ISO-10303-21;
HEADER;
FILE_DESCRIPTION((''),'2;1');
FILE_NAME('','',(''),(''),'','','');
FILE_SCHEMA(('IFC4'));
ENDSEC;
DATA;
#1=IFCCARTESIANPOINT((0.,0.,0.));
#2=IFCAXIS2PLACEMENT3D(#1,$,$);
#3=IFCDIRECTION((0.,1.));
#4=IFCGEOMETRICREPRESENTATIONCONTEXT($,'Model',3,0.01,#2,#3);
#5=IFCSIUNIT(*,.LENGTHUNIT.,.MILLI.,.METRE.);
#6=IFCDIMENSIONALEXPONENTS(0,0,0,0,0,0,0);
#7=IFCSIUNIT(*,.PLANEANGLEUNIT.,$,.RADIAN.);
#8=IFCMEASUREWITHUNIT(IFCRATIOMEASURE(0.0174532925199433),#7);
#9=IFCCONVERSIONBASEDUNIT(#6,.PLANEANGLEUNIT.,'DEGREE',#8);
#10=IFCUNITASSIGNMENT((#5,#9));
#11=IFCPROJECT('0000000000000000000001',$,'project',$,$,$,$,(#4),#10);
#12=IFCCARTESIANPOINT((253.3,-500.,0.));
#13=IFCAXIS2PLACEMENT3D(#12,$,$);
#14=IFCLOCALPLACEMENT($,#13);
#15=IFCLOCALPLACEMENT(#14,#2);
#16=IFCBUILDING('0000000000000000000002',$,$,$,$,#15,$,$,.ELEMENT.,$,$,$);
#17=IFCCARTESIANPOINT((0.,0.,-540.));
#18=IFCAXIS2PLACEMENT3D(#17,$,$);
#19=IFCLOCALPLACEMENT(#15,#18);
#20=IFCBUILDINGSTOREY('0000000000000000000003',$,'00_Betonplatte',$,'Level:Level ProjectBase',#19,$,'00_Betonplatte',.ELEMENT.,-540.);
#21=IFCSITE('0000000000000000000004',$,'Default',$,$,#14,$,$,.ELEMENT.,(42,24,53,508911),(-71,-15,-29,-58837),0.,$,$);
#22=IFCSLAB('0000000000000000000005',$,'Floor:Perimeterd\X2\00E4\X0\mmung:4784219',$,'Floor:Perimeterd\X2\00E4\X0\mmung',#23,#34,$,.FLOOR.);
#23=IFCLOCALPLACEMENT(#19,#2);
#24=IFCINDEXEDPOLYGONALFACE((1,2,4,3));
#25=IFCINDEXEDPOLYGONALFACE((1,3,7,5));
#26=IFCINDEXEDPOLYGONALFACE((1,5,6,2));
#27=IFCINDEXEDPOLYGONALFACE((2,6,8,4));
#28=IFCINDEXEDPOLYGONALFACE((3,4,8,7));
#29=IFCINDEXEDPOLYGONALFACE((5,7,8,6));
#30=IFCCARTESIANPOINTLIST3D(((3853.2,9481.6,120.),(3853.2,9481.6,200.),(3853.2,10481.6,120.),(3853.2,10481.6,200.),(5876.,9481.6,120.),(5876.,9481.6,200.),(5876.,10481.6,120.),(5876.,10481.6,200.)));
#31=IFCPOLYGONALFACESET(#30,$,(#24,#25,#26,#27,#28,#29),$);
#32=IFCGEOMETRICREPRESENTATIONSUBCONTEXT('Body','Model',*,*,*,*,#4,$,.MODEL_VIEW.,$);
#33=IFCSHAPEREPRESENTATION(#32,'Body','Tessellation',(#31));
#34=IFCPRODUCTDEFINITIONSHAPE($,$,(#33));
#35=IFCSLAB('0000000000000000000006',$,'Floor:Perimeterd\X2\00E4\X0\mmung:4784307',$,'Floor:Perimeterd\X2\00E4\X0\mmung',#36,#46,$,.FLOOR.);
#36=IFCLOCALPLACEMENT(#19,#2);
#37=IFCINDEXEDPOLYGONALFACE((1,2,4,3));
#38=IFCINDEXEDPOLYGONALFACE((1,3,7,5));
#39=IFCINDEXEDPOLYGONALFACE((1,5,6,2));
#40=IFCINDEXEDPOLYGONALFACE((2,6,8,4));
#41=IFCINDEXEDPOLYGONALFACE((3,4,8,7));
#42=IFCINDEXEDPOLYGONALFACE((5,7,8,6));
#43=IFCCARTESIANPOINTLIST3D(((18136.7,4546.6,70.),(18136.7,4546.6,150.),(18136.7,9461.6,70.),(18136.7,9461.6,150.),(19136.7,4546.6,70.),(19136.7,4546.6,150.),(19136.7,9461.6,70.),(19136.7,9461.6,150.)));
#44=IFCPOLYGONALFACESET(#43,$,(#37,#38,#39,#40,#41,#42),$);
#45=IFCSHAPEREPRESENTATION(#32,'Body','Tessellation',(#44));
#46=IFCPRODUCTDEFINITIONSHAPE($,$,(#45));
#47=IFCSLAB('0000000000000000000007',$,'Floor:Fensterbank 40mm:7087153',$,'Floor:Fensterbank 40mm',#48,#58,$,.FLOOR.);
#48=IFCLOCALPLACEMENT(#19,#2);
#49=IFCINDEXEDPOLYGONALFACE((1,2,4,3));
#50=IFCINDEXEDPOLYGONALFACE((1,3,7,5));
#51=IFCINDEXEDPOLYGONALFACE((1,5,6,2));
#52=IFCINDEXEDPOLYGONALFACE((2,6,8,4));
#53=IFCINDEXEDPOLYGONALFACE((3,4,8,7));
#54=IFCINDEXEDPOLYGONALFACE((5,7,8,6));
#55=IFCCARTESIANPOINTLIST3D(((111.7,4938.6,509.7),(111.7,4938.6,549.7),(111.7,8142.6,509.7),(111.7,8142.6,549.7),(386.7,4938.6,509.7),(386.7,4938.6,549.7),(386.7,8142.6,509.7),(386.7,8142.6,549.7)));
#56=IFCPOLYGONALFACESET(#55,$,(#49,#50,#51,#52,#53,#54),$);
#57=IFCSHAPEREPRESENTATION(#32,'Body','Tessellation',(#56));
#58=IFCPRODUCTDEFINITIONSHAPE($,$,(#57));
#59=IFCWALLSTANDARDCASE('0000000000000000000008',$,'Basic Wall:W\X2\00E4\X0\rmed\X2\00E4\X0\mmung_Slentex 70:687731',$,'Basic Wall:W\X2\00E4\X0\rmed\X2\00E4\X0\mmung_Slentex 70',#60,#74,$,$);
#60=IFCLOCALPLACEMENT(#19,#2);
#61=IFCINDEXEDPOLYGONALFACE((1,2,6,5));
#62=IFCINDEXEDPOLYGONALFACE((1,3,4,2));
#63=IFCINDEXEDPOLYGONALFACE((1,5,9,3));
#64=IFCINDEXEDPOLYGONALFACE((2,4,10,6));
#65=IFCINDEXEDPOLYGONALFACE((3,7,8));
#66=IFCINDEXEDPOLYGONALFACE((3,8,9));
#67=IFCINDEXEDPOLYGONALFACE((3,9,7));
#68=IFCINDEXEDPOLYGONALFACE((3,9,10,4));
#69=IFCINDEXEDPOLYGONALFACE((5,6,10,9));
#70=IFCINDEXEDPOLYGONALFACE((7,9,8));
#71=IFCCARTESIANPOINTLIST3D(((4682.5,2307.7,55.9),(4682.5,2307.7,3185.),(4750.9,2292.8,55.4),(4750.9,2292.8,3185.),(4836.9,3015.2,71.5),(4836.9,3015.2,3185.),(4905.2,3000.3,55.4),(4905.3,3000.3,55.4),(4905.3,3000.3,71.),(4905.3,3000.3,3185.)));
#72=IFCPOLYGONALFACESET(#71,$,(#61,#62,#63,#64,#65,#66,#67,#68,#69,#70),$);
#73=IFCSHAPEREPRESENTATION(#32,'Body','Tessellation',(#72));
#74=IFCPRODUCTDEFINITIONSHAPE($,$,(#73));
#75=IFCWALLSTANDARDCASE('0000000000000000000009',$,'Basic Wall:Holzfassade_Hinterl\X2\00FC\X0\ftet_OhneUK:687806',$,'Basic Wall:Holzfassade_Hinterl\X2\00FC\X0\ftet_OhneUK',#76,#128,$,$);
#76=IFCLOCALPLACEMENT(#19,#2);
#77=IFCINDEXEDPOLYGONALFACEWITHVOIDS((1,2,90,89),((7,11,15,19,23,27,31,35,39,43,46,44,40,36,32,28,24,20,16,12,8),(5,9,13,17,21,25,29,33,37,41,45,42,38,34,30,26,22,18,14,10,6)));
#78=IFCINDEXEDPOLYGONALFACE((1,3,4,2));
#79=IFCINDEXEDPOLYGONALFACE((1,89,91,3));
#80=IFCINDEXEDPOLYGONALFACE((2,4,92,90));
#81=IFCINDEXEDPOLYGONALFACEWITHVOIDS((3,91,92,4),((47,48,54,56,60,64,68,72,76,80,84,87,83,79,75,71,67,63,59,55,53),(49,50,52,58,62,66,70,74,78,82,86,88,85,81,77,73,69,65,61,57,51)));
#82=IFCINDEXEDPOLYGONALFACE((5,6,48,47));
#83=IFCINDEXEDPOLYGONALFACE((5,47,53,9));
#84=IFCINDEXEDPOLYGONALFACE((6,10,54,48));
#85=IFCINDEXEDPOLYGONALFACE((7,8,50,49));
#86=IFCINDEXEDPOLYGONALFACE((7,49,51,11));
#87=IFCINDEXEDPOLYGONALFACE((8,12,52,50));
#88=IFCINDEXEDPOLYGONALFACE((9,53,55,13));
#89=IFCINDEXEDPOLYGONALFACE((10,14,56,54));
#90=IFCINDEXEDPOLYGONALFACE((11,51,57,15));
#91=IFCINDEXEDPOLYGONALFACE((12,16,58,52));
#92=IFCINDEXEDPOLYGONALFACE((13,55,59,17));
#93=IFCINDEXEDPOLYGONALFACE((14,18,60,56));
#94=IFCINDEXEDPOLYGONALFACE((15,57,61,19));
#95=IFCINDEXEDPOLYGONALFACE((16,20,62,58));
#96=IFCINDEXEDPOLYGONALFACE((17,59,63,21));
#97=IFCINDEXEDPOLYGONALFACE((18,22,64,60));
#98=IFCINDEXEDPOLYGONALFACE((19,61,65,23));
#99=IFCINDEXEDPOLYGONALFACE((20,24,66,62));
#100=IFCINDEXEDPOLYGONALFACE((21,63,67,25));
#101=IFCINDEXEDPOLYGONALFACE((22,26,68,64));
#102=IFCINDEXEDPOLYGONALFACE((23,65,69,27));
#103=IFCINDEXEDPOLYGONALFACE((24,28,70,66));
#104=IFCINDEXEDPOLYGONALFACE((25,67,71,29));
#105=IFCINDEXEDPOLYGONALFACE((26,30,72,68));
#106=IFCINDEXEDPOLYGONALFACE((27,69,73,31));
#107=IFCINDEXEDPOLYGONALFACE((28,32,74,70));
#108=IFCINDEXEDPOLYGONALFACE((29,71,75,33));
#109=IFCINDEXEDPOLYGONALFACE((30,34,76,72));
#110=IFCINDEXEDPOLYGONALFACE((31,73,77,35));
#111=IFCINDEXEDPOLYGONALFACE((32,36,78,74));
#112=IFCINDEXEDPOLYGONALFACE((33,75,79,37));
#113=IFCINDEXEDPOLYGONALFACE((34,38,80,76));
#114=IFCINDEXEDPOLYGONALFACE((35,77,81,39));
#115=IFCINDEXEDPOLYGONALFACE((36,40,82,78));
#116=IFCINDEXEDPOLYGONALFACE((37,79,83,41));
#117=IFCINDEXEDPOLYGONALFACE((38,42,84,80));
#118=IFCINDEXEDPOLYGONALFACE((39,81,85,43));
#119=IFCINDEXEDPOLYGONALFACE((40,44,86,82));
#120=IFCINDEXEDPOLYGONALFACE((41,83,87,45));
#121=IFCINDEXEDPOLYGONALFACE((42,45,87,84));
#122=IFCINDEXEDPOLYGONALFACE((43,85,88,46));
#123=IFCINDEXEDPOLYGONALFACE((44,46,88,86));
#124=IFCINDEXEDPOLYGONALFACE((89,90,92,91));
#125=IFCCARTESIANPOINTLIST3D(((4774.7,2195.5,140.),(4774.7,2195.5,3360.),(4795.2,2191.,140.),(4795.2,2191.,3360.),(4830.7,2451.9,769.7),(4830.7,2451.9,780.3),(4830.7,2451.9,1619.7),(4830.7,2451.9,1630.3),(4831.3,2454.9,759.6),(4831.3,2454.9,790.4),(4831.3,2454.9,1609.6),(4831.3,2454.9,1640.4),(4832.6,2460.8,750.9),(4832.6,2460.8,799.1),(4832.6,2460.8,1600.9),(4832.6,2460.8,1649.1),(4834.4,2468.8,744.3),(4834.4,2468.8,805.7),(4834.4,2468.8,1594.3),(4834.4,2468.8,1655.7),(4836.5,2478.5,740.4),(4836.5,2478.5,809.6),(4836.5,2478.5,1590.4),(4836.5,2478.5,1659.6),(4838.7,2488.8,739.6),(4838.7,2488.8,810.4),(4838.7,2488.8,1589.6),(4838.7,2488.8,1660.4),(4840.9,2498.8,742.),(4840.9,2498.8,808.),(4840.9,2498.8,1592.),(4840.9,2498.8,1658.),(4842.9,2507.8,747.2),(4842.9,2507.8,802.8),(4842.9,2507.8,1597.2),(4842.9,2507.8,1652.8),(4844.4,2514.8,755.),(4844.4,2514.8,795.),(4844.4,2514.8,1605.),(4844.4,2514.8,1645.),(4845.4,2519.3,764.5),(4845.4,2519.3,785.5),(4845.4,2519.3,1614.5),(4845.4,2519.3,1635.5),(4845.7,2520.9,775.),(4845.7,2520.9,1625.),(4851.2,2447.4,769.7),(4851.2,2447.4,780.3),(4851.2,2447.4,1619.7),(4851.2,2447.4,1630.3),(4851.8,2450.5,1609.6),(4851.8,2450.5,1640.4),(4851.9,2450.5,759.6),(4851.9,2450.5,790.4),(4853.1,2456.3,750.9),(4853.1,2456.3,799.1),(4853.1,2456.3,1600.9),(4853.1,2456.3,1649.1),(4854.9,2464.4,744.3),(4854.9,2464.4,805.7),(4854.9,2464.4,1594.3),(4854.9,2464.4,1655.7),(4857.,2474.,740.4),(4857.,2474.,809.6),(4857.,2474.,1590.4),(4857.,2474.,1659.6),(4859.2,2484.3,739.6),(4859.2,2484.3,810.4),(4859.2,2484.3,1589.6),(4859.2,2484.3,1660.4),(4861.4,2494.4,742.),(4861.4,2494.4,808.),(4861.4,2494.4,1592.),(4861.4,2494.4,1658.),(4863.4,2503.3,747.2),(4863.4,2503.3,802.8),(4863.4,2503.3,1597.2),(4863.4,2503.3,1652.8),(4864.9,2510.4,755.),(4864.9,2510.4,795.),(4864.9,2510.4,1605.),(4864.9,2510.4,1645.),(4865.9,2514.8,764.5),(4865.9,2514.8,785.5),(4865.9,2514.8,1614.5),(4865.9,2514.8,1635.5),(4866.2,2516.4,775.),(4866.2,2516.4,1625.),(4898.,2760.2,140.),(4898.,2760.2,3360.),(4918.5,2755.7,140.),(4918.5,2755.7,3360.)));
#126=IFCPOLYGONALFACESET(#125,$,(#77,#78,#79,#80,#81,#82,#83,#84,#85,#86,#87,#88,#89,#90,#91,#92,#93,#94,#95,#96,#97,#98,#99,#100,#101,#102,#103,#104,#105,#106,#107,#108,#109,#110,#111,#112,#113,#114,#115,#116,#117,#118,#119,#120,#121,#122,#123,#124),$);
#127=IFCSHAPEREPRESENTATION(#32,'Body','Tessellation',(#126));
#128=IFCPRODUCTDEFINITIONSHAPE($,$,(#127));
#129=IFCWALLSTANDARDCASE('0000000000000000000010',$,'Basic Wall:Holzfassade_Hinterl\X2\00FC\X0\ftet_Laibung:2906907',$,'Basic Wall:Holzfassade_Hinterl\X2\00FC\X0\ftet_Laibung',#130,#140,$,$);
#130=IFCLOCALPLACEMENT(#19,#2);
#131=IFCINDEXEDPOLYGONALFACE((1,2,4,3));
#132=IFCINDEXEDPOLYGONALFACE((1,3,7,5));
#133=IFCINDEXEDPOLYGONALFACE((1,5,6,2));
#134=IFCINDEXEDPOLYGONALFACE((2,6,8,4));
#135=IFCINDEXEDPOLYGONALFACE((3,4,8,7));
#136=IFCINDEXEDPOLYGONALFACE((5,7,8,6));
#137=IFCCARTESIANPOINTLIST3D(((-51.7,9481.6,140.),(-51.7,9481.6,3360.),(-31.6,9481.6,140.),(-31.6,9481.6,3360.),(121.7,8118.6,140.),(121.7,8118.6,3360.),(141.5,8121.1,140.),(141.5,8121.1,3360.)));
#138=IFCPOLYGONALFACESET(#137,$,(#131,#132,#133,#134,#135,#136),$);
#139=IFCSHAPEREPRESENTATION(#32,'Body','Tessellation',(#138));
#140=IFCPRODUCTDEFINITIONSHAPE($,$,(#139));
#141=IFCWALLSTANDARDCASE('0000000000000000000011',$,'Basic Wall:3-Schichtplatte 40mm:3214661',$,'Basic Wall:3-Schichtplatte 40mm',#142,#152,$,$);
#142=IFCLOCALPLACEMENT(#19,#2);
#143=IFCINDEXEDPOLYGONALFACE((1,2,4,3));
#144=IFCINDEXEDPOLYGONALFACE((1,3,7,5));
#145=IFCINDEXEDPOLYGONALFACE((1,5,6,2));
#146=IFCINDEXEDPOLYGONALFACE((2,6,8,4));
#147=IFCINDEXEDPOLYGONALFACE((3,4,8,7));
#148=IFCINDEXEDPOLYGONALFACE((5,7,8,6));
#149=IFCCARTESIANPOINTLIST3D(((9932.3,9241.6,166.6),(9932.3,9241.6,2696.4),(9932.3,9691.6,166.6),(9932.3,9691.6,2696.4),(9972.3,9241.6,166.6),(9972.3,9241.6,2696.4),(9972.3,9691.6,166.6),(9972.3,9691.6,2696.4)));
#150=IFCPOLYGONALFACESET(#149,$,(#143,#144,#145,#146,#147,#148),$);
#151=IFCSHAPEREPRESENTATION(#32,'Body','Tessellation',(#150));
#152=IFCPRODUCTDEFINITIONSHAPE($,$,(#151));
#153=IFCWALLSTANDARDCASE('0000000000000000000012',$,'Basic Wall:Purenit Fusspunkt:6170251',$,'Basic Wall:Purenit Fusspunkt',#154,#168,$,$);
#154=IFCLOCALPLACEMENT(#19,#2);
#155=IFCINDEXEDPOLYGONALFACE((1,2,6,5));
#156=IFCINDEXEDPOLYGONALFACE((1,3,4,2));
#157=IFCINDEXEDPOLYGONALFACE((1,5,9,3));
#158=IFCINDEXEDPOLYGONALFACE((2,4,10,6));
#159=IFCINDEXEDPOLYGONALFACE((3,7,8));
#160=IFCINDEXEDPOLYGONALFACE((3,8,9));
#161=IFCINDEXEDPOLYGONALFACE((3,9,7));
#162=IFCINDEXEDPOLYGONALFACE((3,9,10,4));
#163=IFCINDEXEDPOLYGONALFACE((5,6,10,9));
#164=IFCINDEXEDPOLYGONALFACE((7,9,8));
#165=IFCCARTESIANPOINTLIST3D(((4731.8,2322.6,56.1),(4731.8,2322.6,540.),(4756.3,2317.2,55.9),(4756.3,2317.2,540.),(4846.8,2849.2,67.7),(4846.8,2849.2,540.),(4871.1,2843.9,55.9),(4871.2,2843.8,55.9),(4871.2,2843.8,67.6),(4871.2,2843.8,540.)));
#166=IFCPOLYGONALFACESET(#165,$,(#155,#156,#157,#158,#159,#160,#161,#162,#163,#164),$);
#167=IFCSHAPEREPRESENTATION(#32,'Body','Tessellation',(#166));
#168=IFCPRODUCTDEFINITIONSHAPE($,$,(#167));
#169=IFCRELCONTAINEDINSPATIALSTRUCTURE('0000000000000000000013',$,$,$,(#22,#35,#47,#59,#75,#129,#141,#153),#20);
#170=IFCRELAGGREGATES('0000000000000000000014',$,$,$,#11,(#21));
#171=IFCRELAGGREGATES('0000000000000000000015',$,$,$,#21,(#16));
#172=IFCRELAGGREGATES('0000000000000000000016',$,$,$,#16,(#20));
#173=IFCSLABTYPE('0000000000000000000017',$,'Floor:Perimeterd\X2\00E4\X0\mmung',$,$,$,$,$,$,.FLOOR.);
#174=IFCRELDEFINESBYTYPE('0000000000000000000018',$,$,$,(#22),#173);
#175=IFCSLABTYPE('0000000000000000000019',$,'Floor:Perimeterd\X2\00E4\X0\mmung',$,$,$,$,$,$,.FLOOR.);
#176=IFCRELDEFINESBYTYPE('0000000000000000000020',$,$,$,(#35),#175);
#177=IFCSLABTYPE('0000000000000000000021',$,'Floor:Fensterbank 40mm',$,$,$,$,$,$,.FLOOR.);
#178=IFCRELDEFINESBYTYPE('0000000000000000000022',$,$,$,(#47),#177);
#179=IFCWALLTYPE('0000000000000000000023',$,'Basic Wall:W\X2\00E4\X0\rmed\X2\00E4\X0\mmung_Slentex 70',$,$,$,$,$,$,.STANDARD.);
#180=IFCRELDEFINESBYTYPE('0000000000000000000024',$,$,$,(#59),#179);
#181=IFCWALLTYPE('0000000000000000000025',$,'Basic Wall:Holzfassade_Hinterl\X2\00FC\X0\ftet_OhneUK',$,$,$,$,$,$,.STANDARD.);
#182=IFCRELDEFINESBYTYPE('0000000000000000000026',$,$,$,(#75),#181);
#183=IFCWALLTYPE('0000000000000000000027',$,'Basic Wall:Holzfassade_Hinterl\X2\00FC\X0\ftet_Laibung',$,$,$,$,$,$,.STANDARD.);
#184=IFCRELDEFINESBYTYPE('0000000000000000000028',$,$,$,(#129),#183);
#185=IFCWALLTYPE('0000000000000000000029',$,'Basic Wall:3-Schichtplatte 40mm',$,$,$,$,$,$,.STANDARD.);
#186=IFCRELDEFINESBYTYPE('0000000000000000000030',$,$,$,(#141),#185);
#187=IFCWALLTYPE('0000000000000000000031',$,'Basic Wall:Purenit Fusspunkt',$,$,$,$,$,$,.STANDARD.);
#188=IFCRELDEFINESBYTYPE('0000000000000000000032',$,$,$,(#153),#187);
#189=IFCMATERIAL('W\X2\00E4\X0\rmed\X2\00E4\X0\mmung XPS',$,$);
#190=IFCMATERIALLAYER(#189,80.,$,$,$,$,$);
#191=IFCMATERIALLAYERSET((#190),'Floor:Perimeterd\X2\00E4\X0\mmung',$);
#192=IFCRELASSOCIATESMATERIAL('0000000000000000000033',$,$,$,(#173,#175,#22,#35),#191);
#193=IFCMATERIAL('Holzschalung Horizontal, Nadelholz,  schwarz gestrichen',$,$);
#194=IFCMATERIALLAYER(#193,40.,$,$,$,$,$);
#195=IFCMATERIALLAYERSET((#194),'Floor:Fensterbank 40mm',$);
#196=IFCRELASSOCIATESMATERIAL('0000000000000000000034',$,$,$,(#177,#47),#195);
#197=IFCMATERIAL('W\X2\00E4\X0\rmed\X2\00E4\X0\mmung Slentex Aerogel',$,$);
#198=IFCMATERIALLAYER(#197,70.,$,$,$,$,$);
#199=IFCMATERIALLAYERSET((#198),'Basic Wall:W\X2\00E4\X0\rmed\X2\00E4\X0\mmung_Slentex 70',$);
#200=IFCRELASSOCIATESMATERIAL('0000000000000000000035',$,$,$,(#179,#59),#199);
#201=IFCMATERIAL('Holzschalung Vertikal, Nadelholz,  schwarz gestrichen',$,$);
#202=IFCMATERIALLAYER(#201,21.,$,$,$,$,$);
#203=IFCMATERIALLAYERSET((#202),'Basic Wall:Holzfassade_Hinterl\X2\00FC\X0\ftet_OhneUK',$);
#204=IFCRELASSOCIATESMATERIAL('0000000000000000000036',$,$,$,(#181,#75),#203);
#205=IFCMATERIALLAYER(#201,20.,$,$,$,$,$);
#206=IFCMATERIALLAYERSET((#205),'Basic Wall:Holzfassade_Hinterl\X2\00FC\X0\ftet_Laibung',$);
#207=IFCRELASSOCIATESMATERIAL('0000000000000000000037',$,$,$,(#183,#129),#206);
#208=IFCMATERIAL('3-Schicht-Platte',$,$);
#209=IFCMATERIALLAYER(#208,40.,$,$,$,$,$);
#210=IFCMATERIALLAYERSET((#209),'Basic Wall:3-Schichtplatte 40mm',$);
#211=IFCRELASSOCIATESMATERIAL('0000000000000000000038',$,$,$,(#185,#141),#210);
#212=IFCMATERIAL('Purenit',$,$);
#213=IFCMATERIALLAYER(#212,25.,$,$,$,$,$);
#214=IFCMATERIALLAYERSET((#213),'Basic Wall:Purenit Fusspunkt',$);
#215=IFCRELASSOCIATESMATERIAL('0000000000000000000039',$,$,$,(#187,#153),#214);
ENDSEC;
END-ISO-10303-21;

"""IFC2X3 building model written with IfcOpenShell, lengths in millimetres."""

from ifc_helpers import new_model, entity, si_unit, converted_unit, direction, frame, frame_2d, origin, origin_2d_with_axis, place, context, subcontext, project, spatial, polyline, rectangle, circle, outline, extrude, clip, bounded_halfspace, material, layer, layer_set, layer_usage, type_object, element, save


model = new_model("IFC2X3")

# Units and contexts
model_context = context("Model", 3, precision=0.01, world=origin(), true_north=direction((0.0, 1.0)))
body_context = subcontext(model_context, "Body", "Model", "MODEL_VIEW")
ifc_project = project(units=[si_unit("LENGTHUNIT", "METRE", prefix="MILLI"), converted_unit("PLANEANGLEUNIT", "DEGREE", entity("IfcRatioMeasure", 0.0174532925199433), si_unit("PLANEANGLEUNIT", "RADIAN"), dimensions=[0, 0, 0, 0, 0, 0, 0])], contexts=[model_context])

# Site, building, storey
site_placement = place(None, frame((253.3, -500.0, 0.0)))
site = spatial("IfcSite", under=ifc_project, at=site_placement, Name="Default", CompositionType="ELEMENT", RefLatitude=(42, 24, 53, 508911), RefLongitude=(-71, -15, -29, -58837), RefElevation=0.0)
building_placement = place(site_placement, origin())
building = spatial("IfcBuilding", under=site, at=building_placement, CompositionType="ELEMENT")
storey_placement = place(building_placement, frame((0.0, 0.0, -540.0)))
storey = spatial("IfcBuildingStorey", under=building, at=storey_placement, Name="00_Betonplatte", ObjectType="Level:Level ProjectBase", LongName="00_Betonplatte", CompositionType="ELEMENT", Elevation=-540.0)

# Slabs
ifc_material_1 = material(Name="Wärmedämmung XPS")
ifc_layer_1 = layer(ifc_material_1, 80.0)
ifc_layer_set_1 = layer_set([ifc_layer_1], Name="Floor:Perimeterdämmung")
ifc_layer_usage_1 = layer_usage(ifc_layer_set_1, "AXIS3", "POSITIVE", 0.0)
slab_type_1 = type_object("IfcSlabType", Name="Floor:Perimeterdämmung", PredefinedType="FLOOR", material=ifc_layer_set_1)
slab_1_placement = place(storey_placement, origin())
element("IfcSlab", 1, at=slab_1_placement, inside=storey, type_object=slab_type_1, material=ifc_layer_usage_1, Name="Floor:Perimeterdämmung:4784219", ObjectType="Floor:Perimeterdämmung", PredefinedType="FLOOR", context=body_context, shape_type="SweptSolid", body=[
    extrude(rectangle(XDim=1000.0, YDim=2022.7, at=frame_2d((0.0, 0.0), x_axis=(1.0, 0.0))), frame((4864.6, 9981.6, 200.0), z_axis=(0.0, 0.0, -1.0), x_axis=(0.0, 1.0, 0.0)), (0.0, 0.0, 1.0), 80.0),
])
ifc_layer_usage_2 = layer_usage(ifc_layer_set_1, "AXIS3", "POSITIVE", 0.0)
slab_type_2 = type_object("IfcSlabType", Name="Floor:Perimeterdämmung", PredefinedType="FLOOR", material=ifc_layer_set_1)
slab_2_placement = place(storey_placement, origin())
element("IfcSlab", 2, at=slab_2_placement, inside=storey, type_object=slab_type_2, material=ifc_layer_usage_2, Name="Floor:Perimeterdämmung:4784307", ObjectType="Floor:Perimeterdämmung", PredefinedType="FLOOR", context=body_context, shape_type="SweptSolid", body=[
    extrude(rectangle(XDim=4915.0, YDim=1000.0, at=frame_2d((0.0, 0.0), x_axis=(1.0, 0.0))), frame((18636.7, 7004.1, 150.0), z_axis=(0.0, 0.0, -1.0), x_axis=(0.0, 1.0, 0.0)), (0.0, 0.0, 1.0), 80.0),
])
ifc_material_2 = material(Name="Holzschalung Horizontal, Nadelholz,  schwarz gestrichen")
ifc_layer_2 = layer(ifc_material_2, 40.0)
ifc_layer_set_2 = layer_set([ifc_layer_2], Name="Floor:Fensterbank 40mm")
ifc_layer_usage_3 = layer_usage(ifc_layer_set_2, "AXIS3", "POSITIVE", 0.0)
slab_type_3 = type_object("IfcSlabType", Name="Floor:Fensterbank 40mm", PredefinedType="FLOOR", material=ifc_layer_set_2)
slab_3_placement = place(storey_placement, origin())
element("IfcSlab", 3, at=slab_3_placement, inside=storey, type_object=slab_type_3, material=ifc_layer_usage_3, Name="Floor:Fensterbank 40mm:7087153", ObjectType="Floor:Fensterbank 40mm", PredefinedType="FLOOR", context=body_context, shape_type="SweptSolid", body=[
    extrude(rectangle(XDim=3204.0, YDim=275.0, at=frame_2d((0.0, 0.0), x_axis=(1.0, 0.0))), frame((249.2, 6540.6, 549.7), z_axis=(0.0, 0.0, -1.0), x_axis=(0.0, 1.0, 0.0)), (0.0, 0.0, 1.0), 40.0),
])

# Wall
ifc_material_3 = material(Name="Wärmedämmung Slentex Aerogel")
ifc_layer_3 = layer(ifc_material_3, 70.0)
ifc_layer_set_3 = layer_set([ifc_layer_3], Name="Basic Wall:Wärmedämmung_Slentex 70")
ifc_layer_usage_4 = layer_usage(ifc_layer_set_3, "AXIS2", "POSITIVE", -35.0)
wall_type_1 = type_object("IfcWallType", Name="Basic Wall:Wärmedämmung_Slentex 70", PredefinedType="STANDARD", material=ifc_layer_set_3)
wall_1_placement = place(storey_placement, frame((4716.7, 2300.3, 55.4), z_axis=(0.0, 0.0, 1.0), x_axis=(0.213201, 0.977008, 0.0)))
element("IfcWallStandardCase", 4, at=wall_1_placement, inside=storey, type_object=wall_type_1, material=ifc_layer_usage_4, Name="Basic Wall:Wärmedämmung_Slentex 70:687731", ObjectType="Basic Wall:Wärmedämmung_Slentex 70", context=body_context, shape_type="Clipping", body=[
    clip(extrude(rectangle(XDim=724.1, YDim=70.0, at=frame_2d((362.1, 0.0), x_axis=(-1.0, 0.0))), origin(), (0.0, 0.0, 1.0), 3129.6), bounded_halfspace(frame((724.1, -35.0, 15.7), z_axis=(-0.021628, -0.007363, 0.999739), x_axis=(0.2132, -0.977005, -0.002583)), True, frame((724.1, -35.0, 15.7), z_axis=(-0.021628, -0.007363, 0.999739), x_axis=(0.2132, -0.977005, -0.002583)), polyline([(0.0, 0.0), (-68.4, 14.9), (-180.1, -497.3), (-217.4, -668.3), (-222.7, -692.7), (-154.3, -707.6), (0.0, 0.0)]))),
])

# Wall, openings
ifc_material_4 = material(Name="Holzschalung Vertikal, Nadelholz,  schwarz gestrichen")
ifc_layer_4 = layer(ifc_material_4, 21.0)
ifc_layer_set_4 = layer_set([ifc_layer_4], Name="Basic Wall:Holzfassade_Hinterlüftet_OhneUK")
ifc_layer_usage_5 = layer_usage(ifc_layer_set_4, "AXIS2", "NEGATIVE", 10.5)
wall_type_2 = type_object("IfcWallType", Name="Basic Wall:Holzfassade_Hinterlüftet_OhneUK", PredefinedType="STANDARD", material=ifc_layer_set_4)
wall_2_placement = place(storey_placement, frame((4908.2, 2757.9, 140.0), z_axis=(0.0, 0.0, 1.0), x_axis=(-0.213201, -0.977008, 0.0)))
wall_2 = element("IfcWallStandardCase", 5, at=wall_2_placement, inside=storey, type_object=wall_type_2, material=ifc_layer_usage_5, Name="Basic Wall:Holzfassade_Hinterlüftet_OhneUK:687806", ObjectType="Basic Wall:Holzfassade_Hinterlüftet_OhneUK", context=body_context, shape_type="SweptSolid", body=[
    extrude(rectangle(XDim=578.0, YDim=21.0, at=frame_2d((289.0, 0.0), x_axis=(-1.0, 0.0))), origin(), (0.0, 0.0, 1.0), 3220.0),
])
opening_1_placement = place(wall_2_placement, frame((330.1, -46.7, 597.9)))
element("IfcOpeningElement", 6, at=opening_1_placement, cuts=wall_2, ObjectType="Opening", context=body_context, shape_type="SweptSolid", body=[
    extrude(circle(Radius=35.5, at=frame_2d((0.0, 0.0), x_axis=(1.0, 0.0))), frame((-49.7, -1.5, 37.1), z_axis=(0.0, 1.0, 0.0), x_axis=(-1.0, 0.0, 0.0)), (0.0, 0.0, 1.0), 59.0),
])
opening_2_placement = place(wall_2_placement, frame((330.1, -47.1, 1447.9)))
element("IfcOpeningElement", 7, at=opening_2_placement, cuts=wall_2, ObjectType="Opening", context=body_context, shape_type="SweptSolid", body=[
    extrude(circle(Radius=35.5, at=origin_2d_with_axis()), frame((-49.7, -1.5, 37.1), z_axis=(0.0, 1.0, 0.0), x_axis=(-1.0, 0.0, 0.0)), (0.0, 0.0, 1.0), 59.0),
])

# Walls
ifc_layer_5 = layer(ifc_material_4, 20.0)
ifc_layer_set_5 = layer_set([ifc_layer_5], Name="Basic Wall:Holzfassade_Hinterlüftet_Laibung")
wall_type_3 = type_object("IfcWallType", Name="Basic Wall:Holzfassade_Hinterlüftet_Laibung", PredefinedType="STANDARD", material=ifc_layer_set_5)
ifc_layer_usage_6 = layer_usage(ifc_layer_set_5, "AXIS2", "NEGATIVE", 10.0)
wall_3_placement = place(storey_placement, frame((131.6, 8119.9, 140.0), z_axis=(0.0, 0.0, 1.0), x_axis=(-0.126186, 0.992007, 0.0)))
element("IfcWallStandardCase", 8, at=wall_3_placement, inside=storey, type_object=wall_type_3, material=ifc_layer_usage_6, Name="Basic Wall:Holzfassade_Hinterlüftet_Laibung:2906907", ObjectType="Basic Wall:Holzfassade_Hinterlüftet_Laibung", context=body_context, shape_type="SweptSolid", body=[
    extrude(outline(polyline([(1371.5, -10.0), (1374.0, 10.0), (0.0, 10.0), (0.0, -10.0), (1371.5, -10.0)])), origin(), (0.0, 0.0, 1.0), 3220.0),
])
ifc_material_5 = material(Name="3-Schicht-Platte")
ifc_layer_6 = layer(ifc_material_5, 40.0)
ifc_layer_set_6 = layer_set([ifc_layer_6], Name="Basic Wall:3-Schichtplatte 40mm")
ifc_layer_usage_7 = layer_usage(ifc_layer_set_6, "AXIS2", "POSITIVE", -20.0)
wall_type_4 = type_object("IfcWallType", Name="Basic Wall:3-Schichtplatte 40mm", PredefinedType="STANDARD", material=ifc_layer_set_6)
wall_4_placement = place(storey_placement, frame((9952.3, 9691.6, 166.6), z_axis=(0.0, 0.0, 1.0), x_axis=(0.0, -1.0, 0.0)))
element("IfcWallStandardCase", 9, at=wall_4_placement, inside=storey, type_object=wall_type_4, material=ifc_layer_usage_7, Name="Basic Wall:3-Schichtplatte 40mm:3214661", ObjectType="Basic Wall:3-Schichtplatte 40mm", context=body_context, shape_type="SweptSolid", body=[
    extrude(rectangle(XDim=450.0, YDim=40.0, at=frame_2d((225.0, 0.0), x_axis=(-1.0, 0.0))), origin(), (0.0, 0.0, 1.0), 2529.7),
])
ifc_material_6 = material(Name="Purenit")
ifc_layer_7 = layer(ifc_material_6, 25.0)
ifc_layer_set_7 = layer_set([ifc_layer_7], Name="Basic Wall:Purenit Fusspunkt")
ifc_layer_usage_8 = layer_usage(ifc_layer_set_7, "AXIS2", "POSITIVE", -12.5)
wall_type_5 = type_object("IfcWallType", Name="Basic Wall:Purenit Fusspunkt", PredefinedType="STANDARD", material=ifc_layer_set_7)
wall_5_placement = place(storey_placement, frame((4859.0, 2846.5, 55.9), z_axis=(0.0, 0.0, 1.0), x_axis=(-0.213201, -0.977008, 0.0)))
element("IfcWallStandardCase", 10, at=wall_5_placement, inside=storey, type_object=wall_type_5, material=ifc_layer_usage_8, Name="Basic Wall:Purenit Fusspunkt:6170251", ObjectType="Basic Wall:Purenit Fusspunkt", context=body_context, shape_type="Clipping", body=[
    clip(extrude(rectangle(XDim=539.0, YDim=25.0, at=frame_2d((269.5, 0.0), x_axis=(-1.0, 0.0))), origin(), (0.0, 0.0, 1.0), 484.1), bounded_halfspace(frame((539.0, -12.5, 0.2), z_axis=(0.021628, 0.007363, 0.999739), x_axis=(-0.2132, 0.977005, -0.002583)), True, frame((539.0, -12.5, 0.2), z_axis=(0.021628, 0.007363, 0.999739), x_axis=(-0.2132, 0.977005, -0.002583)), polyline([(0.0, 0.0), (24.4, -5.3), (139.3, 521.4), (114.9, 526.7), (0.0, 0.0)]))),
])

save(model, "model.ifc")
